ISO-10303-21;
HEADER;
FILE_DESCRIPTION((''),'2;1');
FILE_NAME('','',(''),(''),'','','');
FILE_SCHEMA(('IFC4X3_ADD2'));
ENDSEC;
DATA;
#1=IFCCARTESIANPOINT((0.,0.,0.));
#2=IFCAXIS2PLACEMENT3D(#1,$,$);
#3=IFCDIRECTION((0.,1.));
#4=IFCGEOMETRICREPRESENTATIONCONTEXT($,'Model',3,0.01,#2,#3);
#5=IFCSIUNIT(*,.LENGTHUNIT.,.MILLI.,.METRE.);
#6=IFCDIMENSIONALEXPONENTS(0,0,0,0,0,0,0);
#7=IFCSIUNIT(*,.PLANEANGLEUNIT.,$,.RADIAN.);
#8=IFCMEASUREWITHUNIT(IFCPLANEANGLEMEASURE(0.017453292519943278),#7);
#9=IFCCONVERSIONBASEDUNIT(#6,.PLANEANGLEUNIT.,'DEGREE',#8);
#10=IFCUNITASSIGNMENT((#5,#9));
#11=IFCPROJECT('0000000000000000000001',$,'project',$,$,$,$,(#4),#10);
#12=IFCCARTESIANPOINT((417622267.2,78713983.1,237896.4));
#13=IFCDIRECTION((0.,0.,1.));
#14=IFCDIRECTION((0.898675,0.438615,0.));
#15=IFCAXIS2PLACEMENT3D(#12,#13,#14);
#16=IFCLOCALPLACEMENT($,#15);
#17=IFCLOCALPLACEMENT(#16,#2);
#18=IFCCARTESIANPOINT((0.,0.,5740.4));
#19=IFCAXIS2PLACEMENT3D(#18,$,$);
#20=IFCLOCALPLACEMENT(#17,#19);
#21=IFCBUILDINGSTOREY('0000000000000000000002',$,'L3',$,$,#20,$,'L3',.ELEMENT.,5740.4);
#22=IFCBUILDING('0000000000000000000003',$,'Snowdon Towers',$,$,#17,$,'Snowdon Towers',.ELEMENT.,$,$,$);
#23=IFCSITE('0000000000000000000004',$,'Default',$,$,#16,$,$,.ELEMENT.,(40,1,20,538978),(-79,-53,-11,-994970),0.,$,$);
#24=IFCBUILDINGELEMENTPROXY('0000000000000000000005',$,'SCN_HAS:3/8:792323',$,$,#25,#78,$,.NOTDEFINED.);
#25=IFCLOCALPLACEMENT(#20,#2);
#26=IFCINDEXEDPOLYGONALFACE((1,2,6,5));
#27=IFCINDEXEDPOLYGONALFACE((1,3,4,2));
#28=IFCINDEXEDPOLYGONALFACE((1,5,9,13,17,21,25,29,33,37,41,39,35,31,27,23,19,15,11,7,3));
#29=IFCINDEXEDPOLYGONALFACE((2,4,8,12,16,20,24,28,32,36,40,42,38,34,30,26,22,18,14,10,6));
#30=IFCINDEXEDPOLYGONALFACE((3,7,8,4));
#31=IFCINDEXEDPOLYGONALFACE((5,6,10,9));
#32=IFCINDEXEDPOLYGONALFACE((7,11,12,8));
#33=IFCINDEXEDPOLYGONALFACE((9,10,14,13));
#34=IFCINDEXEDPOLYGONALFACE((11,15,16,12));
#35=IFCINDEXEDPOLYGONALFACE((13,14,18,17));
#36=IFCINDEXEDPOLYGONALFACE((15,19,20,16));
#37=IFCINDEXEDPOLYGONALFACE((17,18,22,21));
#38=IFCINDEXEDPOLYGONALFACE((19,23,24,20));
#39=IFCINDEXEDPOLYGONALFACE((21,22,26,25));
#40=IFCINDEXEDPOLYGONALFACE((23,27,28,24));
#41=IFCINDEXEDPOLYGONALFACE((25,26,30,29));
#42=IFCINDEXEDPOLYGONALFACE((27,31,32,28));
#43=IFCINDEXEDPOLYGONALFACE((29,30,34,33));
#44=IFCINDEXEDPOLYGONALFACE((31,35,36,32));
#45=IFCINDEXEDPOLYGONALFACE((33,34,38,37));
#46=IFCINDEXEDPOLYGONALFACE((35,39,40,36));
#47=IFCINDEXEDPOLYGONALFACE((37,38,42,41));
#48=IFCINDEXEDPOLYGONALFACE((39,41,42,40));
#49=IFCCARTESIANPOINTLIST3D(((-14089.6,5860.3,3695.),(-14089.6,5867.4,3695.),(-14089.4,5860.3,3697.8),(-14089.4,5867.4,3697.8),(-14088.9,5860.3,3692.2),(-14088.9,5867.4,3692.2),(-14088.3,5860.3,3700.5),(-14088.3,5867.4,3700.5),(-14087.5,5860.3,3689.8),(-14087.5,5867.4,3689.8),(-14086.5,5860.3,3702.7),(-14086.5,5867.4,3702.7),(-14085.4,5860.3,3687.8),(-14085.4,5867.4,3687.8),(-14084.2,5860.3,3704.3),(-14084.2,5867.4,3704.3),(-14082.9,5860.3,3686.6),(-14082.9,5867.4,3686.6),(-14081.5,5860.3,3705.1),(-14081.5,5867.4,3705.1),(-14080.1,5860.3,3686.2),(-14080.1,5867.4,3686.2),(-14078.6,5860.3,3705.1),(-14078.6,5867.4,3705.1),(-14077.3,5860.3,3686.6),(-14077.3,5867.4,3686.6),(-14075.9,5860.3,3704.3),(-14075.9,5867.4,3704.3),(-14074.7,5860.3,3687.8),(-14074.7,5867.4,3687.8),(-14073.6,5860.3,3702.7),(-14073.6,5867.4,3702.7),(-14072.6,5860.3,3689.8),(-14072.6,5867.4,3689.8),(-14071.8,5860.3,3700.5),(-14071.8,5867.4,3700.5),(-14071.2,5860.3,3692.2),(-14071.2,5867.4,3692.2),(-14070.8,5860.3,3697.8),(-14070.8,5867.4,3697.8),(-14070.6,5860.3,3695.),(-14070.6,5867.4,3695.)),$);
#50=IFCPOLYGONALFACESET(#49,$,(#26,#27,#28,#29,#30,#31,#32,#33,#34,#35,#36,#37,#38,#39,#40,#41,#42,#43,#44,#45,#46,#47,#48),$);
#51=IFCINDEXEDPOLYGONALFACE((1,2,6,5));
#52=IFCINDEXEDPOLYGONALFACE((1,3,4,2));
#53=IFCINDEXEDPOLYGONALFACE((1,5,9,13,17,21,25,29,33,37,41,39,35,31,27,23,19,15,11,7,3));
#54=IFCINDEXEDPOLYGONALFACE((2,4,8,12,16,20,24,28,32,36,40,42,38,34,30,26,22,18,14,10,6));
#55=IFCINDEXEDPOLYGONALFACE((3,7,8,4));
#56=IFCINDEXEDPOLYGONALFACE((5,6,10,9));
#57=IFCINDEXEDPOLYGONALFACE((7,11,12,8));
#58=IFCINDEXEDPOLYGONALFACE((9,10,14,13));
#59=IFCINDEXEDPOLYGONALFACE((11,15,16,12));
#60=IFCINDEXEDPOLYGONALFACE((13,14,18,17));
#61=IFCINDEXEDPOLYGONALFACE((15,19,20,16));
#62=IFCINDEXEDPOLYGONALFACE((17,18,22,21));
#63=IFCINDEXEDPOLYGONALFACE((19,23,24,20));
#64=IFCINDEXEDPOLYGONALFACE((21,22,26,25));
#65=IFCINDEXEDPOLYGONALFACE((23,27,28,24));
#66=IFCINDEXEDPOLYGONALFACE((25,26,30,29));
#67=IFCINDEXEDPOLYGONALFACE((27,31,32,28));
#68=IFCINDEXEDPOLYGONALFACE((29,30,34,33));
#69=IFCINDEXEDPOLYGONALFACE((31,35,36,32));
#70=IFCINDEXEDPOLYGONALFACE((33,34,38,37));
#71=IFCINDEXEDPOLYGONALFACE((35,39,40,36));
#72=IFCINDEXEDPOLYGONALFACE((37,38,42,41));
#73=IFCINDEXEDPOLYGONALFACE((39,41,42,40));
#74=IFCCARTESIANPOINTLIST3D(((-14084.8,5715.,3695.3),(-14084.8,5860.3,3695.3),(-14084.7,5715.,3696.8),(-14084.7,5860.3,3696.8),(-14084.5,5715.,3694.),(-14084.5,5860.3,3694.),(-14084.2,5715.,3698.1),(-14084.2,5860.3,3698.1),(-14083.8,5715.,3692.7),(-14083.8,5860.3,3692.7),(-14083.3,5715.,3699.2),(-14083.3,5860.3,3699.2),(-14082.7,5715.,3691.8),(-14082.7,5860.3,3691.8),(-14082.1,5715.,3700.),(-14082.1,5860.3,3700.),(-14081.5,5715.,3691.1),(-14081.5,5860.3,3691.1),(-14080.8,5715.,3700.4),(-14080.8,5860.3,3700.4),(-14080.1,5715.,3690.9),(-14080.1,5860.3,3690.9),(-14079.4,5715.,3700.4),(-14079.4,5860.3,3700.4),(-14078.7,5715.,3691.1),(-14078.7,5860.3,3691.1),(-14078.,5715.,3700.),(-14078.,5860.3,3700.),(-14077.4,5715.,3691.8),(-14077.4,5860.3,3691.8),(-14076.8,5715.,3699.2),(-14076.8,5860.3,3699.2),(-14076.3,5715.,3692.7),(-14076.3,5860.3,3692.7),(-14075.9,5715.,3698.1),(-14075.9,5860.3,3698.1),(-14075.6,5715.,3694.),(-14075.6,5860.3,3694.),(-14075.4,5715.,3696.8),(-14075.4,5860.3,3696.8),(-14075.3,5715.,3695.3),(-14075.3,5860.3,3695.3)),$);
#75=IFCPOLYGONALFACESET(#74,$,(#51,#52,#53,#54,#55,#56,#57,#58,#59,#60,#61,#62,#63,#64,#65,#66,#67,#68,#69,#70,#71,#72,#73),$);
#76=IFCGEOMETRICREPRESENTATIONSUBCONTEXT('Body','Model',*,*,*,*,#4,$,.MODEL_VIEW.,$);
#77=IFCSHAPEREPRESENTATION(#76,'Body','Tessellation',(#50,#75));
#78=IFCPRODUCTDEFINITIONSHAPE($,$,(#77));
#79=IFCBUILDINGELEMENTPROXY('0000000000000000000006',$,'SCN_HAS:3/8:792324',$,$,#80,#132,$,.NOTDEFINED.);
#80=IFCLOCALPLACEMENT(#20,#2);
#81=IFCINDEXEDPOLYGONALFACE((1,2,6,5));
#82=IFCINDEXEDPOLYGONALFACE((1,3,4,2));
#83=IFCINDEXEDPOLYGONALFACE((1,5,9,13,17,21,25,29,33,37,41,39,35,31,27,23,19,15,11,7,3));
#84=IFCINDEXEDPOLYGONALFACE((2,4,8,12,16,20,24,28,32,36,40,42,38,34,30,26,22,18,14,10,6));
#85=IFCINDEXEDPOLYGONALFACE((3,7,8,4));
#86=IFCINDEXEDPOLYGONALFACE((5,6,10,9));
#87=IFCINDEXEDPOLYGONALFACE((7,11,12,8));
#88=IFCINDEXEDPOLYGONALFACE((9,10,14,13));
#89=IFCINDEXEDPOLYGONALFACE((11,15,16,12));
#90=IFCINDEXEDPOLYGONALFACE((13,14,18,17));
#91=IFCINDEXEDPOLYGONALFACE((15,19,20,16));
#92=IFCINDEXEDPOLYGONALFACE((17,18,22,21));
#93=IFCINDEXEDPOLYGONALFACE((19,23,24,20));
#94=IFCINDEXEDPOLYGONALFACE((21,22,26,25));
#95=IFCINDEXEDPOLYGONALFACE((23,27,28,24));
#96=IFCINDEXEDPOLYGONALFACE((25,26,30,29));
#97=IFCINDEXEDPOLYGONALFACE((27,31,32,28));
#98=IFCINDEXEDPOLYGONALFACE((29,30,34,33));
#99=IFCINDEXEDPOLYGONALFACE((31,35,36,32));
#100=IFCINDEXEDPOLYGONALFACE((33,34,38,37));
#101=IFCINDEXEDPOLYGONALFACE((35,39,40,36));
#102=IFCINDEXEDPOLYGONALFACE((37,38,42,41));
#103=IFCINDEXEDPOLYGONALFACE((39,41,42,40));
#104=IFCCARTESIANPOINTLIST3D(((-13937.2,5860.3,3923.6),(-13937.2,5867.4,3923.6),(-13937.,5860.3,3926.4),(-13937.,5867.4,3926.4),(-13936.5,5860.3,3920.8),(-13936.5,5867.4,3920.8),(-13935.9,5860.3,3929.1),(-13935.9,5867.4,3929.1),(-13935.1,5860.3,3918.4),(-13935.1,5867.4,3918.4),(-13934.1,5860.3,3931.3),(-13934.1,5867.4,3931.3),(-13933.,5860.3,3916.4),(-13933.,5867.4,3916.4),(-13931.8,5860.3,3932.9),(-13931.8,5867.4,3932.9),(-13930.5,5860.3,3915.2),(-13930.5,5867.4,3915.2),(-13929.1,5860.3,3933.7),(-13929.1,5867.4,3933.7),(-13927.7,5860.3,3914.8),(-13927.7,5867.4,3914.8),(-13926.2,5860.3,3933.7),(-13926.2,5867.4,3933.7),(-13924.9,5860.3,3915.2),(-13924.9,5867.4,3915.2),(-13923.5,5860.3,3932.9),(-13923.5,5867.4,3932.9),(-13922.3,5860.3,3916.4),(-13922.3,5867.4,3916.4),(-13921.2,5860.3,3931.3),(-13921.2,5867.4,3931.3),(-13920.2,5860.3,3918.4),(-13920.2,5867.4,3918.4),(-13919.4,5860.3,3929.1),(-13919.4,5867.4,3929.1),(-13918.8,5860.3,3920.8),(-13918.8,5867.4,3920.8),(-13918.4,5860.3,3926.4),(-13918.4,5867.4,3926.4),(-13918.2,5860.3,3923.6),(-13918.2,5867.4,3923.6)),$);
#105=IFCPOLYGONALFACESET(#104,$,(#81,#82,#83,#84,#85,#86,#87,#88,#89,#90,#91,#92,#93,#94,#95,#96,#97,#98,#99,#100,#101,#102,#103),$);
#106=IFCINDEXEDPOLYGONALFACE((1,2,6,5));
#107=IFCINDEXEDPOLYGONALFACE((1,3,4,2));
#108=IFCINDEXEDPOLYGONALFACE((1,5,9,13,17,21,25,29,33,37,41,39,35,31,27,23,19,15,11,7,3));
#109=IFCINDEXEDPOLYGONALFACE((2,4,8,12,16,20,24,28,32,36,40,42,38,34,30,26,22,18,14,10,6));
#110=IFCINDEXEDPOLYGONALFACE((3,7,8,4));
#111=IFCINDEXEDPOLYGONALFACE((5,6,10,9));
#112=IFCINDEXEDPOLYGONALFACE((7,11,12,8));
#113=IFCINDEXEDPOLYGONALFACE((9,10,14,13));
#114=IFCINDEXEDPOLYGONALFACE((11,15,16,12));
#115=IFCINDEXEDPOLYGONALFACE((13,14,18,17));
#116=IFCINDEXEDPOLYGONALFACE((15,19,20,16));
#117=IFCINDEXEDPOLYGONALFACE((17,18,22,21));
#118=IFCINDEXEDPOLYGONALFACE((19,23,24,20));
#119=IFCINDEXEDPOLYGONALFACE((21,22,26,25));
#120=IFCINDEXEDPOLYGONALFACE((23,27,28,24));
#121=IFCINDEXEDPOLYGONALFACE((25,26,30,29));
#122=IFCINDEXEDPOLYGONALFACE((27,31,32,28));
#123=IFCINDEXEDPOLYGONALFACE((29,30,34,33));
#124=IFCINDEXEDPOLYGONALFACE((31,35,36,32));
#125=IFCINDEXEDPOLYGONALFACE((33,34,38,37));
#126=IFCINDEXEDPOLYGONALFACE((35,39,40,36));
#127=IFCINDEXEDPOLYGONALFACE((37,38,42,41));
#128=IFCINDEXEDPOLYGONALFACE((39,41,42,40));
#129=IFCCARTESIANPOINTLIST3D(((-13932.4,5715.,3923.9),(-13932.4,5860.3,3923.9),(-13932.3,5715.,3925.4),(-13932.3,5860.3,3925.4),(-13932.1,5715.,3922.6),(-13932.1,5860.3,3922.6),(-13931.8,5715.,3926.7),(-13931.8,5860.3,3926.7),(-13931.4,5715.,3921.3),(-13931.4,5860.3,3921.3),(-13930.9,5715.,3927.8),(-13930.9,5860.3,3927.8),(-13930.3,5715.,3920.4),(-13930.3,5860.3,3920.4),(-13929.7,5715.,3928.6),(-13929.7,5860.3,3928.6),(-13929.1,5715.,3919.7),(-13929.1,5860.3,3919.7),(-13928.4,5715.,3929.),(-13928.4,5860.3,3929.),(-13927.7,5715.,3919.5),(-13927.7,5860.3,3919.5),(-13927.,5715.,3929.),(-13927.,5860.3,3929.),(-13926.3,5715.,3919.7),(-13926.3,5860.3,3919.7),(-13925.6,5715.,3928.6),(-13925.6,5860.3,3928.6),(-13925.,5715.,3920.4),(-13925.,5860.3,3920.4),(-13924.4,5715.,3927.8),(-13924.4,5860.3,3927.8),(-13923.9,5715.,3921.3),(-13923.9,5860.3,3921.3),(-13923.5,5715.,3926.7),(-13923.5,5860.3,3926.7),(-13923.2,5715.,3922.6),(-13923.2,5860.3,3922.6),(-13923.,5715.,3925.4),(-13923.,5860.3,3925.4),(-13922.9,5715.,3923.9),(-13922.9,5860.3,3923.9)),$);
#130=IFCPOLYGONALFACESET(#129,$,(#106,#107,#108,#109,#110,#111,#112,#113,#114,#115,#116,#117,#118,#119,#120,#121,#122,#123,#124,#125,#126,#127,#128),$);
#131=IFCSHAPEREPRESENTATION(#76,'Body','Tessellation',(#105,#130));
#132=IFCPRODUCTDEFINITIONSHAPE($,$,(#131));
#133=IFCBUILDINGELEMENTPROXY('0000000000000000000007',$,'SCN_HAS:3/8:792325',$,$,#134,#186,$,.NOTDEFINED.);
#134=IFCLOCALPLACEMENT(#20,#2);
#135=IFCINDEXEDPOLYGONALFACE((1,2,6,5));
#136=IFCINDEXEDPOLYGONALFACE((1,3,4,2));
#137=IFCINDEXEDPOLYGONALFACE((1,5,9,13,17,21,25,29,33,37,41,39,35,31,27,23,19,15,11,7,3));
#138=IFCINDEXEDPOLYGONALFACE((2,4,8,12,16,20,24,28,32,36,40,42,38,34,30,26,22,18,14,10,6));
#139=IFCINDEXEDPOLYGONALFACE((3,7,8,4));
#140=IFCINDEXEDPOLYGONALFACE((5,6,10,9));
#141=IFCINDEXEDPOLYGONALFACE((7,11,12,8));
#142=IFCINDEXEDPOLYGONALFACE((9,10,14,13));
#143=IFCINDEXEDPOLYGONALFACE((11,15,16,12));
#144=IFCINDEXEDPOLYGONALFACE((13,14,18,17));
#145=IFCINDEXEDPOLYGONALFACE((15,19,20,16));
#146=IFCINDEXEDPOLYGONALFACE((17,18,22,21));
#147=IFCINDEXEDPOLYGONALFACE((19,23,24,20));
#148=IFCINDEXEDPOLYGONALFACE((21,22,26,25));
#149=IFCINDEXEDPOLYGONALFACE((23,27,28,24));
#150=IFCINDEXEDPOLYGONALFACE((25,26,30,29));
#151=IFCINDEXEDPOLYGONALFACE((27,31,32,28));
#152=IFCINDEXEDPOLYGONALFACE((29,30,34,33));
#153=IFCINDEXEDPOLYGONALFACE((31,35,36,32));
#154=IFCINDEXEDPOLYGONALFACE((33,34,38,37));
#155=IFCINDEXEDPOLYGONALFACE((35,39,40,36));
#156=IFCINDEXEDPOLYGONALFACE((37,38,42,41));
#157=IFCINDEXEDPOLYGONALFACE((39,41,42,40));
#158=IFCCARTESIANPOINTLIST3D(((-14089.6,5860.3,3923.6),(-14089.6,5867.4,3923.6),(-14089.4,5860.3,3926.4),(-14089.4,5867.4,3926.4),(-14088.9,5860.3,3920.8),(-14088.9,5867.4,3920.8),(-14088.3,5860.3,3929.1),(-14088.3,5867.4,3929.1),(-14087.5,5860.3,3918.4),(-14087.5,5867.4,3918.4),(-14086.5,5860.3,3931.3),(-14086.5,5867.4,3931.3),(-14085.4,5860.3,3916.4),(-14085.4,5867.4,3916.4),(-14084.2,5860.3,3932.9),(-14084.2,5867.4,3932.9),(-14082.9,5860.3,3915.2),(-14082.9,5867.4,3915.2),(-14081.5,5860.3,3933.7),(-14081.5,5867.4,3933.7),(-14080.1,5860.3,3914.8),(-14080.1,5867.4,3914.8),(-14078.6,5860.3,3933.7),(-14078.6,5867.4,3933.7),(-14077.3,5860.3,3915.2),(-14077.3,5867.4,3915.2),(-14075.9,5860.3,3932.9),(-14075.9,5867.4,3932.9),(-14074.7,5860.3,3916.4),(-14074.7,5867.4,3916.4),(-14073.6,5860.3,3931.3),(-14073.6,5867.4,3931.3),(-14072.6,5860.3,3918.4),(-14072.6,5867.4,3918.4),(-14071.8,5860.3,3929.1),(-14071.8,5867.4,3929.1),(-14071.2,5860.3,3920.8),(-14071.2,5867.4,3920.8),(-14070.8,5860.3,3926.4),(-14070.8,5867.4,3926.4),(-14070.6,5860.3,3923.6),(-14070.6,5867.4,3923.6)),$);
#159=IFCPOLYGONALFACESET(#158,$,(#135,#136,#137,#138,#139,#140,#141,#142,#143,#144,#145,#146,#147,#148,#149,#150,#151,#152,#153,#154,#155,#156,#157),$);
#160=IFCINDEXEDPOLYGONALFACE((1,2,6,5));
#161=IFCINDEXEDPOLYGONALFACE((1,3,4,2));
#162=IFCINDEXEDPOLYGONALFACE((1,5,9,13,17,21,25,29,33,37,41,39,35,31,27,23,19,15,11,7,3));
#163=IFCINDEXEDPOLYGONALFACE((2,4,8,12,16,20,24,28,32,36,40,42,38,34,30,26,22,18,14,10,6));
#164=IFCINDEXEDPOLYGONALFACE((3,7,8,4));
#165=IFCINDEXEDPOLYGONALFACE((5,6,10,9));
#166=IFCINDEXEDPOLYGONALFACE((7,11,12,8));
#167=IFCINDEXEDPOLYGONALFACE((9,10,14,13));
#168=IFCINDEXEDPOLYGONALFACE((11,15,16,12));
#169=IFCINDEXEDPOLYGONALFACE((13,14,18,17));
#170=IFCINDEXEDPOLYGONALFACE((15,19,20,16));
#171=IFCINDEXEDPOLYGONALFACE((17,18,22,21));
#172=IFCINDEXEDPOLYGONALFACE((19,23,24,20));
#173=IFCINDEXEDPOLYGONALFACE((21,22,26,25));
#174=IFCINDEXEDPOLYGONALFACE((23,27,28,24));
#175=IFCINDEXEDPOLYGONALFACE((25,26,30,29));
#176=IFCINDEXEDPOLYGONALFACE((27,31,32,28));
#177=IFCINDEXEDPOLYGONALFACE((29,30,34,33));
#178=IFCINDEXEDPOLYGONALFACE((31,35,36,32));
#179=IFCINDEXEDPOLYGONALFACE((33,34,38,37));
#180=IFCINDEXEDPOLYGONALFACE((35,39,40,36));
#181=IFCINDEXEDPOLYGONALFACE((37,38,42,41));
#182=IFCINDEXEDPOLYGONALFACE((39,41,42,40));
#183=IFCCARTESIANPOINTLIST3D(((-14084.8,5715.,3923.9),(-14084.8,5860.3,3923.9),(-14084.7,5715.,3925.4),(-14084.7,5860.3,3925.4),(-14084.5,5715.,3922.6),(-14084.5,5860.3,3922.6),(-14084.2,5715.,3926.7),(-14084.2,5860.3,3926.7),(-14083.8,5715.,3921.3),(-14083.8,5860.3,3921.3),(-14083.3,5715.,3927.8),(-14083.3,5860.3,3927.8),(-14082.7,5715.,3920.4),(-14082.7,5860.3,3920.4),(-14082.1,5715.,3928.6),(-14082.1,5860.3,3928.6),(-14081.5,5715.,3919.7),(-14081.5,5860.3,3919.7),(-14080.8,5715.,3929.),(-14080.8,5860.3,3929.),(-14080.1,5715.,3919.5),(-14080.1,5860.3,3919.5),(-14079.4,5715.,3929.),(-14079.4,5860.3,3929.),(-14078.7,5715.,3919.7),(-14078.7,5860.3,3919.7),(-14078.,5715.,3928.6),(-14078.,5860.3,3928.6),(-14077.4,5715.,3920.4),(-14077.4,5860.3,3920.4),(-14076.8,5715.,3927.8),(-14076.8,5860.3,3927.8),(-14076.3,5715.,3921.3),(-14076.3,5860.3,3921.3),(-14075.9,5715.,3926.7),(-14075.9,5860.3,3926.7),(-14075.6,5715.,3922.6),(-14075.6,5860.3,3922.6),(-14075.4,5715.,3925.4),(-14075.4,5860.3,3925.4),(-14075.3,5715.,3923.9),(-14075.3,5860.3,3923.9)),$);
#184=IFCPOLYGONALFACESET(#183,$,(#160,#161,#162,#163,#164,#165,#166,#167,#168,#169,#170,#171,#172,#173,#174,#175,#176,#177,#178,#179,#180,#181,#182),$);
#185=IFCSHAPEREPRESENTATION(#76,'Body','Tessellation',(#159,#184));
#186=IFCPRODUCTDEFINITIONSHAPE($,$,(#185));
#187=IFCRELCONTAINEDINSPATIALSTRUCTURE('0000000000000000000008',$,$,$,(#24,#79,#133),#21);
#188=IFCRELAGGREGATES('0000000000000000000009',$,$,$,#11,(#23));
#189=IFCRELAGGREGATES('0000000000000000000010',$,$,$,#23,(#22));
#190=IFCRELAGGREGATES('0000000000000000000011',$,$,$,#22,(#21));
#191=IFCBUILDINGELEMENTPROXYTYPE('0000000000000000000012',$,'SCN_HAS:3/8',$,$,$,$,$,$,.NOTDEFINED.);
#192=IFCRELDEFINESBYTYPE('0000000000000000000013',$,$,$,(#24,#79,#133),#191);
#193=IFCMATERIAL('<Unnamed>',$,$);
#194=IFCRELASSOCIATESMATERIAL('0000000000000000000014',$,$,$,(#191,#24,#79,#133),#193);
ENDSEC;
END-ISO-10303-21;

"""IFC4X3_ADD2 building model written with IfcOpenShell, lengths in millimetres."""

from ifc_helpers import new_model, entity, si_unit, converted_unit, direction, frame, frame_2d, origin, place, context, subcontext, project, spatial, circle, extrude, source, transform, mapped, material, type_object, type_shapes, element, save


model = new_model("IFC4X3_ADD2")

# Units and contexts
model_context = context("Model", 3, precision=0.01, world=origin(), true_north=direction((0.0, 1.0)))
body_context = subcontext(model_context, "Body", "Model", "MODEL_VIEW")
ifc_project = project(units=[si_unit("LENGTHUNIT", "METRE", prefix="MILLI"), converted_unit("PLANEANGLEUNIT", "DEGREE", entity("IfcPlaneAngleMeasure", 0.017453292519943278), si_unit("PLANEANGLEUNIT", "RADIAN"), dimensions=[0, 0, 0, 0, 0, 0, 0])], contexts=[model_context])

# Site, building, storey
site_placement = place(None, frame((417622267.2, 78713983.1, 237896.4), z_axis=(0.0, 0.0, 1.0), x_axis=(0.898675, 0.438615, 0.0)))
site = spatial("IfcSite", under=ifc_project, at=site_placement, Name="Default", CompositionType="ELEMENT", RefLatitude=(40, 1, 20, 538978), RefLongitude=(-79, -53, -11, -994970), RefElevation=0.0)
building_placement = place(site_placement, origin())
building = spatial("IfcBuilding", under=site, at=building_placement, Name="Snowdon Towers", LongName="Snowdon Towers", CompositionType="ELEMENT")
storey_placement = place(building_placement, frame((0.0, 0.0, 5740.4)))
storey = spatial("IfcBuildingStorey", under=building, at=storey_placement, Name="L3", LongName="L3", CompositionType="ELEMENT", Elevation=5740.4)

# Building element proxies
ifc_material_1 = material(Name="<Unnamed>")
building_element_proxy_type_1 = type_object("IfcBuildingElementProxyType", Name="SCN_HAS:3/8", PredefinedType="NOTDEFINED", material=ifc_material_1)
shared_shape_1 = source(origin(), body_context, "Body", "SweptSolid", [
    extrude(circle(Radius=9.5, at=frame_2d((0.0, 0.0), x_axis=(1.0, 0.0))), frame((0.0, 0.0, -152.4), z_axis=(0.0, 0.0, 1.0), x_axis=(0.0, -1.0, 0.0)), (0.0, 0.0, 1.0), 7.1),
    extrude(circle(Radius=4.8, at=frame_2d((0.0, 0.0), x_axis=(1.0, 0.0))), frame((0.0, 0.0, -145.3), z_axis=(0.0, 0.0, 1.0), x_axis=(0.0, -1.0, 0.0)), (0.0, 0.0, 1.0), 145.3),
])
type_shapes(building_element_proxy_type_1, [shared_shape_1])
for number, where, z_axis, x_axis, name in (
    (1, (-14080.1, 5715.0, 3695.7), (0.0, -1.0, 0.0), (1.0, 0.0, 0.0), "SCN_HAS:3/8:792323"),
    (2, (-13927.7, 5715.0, 3924.3), (0.0, -1.0, 0.0), (1.0, 0.0, 0.0), "SCN_HAS:3/8:792324"),
    (3, (-14080.1, 5715.0, 3924.3), (0.0, -1.0, 0.0), (1.0, 0.0, 0.0), "SCN_HAS:3/8:792325"),
):
    element("IfcBuildingElementProxy", number, at=place(storey_placement, frame(where, z_axis=z_axis, x_axis=x_axis)), inside=storey, type_object=building_element_proxy_type_1, material=ifc_material_1, Name=name, PredefinedType="NOTDEFINED", context=body_context, shape_type="MappedRepresentation", body=[
        mapped(shared_shape_1, transform((0.0, 0.0, 0.0), scale=1.0)),
    ])

save(model, "model.ifc")
